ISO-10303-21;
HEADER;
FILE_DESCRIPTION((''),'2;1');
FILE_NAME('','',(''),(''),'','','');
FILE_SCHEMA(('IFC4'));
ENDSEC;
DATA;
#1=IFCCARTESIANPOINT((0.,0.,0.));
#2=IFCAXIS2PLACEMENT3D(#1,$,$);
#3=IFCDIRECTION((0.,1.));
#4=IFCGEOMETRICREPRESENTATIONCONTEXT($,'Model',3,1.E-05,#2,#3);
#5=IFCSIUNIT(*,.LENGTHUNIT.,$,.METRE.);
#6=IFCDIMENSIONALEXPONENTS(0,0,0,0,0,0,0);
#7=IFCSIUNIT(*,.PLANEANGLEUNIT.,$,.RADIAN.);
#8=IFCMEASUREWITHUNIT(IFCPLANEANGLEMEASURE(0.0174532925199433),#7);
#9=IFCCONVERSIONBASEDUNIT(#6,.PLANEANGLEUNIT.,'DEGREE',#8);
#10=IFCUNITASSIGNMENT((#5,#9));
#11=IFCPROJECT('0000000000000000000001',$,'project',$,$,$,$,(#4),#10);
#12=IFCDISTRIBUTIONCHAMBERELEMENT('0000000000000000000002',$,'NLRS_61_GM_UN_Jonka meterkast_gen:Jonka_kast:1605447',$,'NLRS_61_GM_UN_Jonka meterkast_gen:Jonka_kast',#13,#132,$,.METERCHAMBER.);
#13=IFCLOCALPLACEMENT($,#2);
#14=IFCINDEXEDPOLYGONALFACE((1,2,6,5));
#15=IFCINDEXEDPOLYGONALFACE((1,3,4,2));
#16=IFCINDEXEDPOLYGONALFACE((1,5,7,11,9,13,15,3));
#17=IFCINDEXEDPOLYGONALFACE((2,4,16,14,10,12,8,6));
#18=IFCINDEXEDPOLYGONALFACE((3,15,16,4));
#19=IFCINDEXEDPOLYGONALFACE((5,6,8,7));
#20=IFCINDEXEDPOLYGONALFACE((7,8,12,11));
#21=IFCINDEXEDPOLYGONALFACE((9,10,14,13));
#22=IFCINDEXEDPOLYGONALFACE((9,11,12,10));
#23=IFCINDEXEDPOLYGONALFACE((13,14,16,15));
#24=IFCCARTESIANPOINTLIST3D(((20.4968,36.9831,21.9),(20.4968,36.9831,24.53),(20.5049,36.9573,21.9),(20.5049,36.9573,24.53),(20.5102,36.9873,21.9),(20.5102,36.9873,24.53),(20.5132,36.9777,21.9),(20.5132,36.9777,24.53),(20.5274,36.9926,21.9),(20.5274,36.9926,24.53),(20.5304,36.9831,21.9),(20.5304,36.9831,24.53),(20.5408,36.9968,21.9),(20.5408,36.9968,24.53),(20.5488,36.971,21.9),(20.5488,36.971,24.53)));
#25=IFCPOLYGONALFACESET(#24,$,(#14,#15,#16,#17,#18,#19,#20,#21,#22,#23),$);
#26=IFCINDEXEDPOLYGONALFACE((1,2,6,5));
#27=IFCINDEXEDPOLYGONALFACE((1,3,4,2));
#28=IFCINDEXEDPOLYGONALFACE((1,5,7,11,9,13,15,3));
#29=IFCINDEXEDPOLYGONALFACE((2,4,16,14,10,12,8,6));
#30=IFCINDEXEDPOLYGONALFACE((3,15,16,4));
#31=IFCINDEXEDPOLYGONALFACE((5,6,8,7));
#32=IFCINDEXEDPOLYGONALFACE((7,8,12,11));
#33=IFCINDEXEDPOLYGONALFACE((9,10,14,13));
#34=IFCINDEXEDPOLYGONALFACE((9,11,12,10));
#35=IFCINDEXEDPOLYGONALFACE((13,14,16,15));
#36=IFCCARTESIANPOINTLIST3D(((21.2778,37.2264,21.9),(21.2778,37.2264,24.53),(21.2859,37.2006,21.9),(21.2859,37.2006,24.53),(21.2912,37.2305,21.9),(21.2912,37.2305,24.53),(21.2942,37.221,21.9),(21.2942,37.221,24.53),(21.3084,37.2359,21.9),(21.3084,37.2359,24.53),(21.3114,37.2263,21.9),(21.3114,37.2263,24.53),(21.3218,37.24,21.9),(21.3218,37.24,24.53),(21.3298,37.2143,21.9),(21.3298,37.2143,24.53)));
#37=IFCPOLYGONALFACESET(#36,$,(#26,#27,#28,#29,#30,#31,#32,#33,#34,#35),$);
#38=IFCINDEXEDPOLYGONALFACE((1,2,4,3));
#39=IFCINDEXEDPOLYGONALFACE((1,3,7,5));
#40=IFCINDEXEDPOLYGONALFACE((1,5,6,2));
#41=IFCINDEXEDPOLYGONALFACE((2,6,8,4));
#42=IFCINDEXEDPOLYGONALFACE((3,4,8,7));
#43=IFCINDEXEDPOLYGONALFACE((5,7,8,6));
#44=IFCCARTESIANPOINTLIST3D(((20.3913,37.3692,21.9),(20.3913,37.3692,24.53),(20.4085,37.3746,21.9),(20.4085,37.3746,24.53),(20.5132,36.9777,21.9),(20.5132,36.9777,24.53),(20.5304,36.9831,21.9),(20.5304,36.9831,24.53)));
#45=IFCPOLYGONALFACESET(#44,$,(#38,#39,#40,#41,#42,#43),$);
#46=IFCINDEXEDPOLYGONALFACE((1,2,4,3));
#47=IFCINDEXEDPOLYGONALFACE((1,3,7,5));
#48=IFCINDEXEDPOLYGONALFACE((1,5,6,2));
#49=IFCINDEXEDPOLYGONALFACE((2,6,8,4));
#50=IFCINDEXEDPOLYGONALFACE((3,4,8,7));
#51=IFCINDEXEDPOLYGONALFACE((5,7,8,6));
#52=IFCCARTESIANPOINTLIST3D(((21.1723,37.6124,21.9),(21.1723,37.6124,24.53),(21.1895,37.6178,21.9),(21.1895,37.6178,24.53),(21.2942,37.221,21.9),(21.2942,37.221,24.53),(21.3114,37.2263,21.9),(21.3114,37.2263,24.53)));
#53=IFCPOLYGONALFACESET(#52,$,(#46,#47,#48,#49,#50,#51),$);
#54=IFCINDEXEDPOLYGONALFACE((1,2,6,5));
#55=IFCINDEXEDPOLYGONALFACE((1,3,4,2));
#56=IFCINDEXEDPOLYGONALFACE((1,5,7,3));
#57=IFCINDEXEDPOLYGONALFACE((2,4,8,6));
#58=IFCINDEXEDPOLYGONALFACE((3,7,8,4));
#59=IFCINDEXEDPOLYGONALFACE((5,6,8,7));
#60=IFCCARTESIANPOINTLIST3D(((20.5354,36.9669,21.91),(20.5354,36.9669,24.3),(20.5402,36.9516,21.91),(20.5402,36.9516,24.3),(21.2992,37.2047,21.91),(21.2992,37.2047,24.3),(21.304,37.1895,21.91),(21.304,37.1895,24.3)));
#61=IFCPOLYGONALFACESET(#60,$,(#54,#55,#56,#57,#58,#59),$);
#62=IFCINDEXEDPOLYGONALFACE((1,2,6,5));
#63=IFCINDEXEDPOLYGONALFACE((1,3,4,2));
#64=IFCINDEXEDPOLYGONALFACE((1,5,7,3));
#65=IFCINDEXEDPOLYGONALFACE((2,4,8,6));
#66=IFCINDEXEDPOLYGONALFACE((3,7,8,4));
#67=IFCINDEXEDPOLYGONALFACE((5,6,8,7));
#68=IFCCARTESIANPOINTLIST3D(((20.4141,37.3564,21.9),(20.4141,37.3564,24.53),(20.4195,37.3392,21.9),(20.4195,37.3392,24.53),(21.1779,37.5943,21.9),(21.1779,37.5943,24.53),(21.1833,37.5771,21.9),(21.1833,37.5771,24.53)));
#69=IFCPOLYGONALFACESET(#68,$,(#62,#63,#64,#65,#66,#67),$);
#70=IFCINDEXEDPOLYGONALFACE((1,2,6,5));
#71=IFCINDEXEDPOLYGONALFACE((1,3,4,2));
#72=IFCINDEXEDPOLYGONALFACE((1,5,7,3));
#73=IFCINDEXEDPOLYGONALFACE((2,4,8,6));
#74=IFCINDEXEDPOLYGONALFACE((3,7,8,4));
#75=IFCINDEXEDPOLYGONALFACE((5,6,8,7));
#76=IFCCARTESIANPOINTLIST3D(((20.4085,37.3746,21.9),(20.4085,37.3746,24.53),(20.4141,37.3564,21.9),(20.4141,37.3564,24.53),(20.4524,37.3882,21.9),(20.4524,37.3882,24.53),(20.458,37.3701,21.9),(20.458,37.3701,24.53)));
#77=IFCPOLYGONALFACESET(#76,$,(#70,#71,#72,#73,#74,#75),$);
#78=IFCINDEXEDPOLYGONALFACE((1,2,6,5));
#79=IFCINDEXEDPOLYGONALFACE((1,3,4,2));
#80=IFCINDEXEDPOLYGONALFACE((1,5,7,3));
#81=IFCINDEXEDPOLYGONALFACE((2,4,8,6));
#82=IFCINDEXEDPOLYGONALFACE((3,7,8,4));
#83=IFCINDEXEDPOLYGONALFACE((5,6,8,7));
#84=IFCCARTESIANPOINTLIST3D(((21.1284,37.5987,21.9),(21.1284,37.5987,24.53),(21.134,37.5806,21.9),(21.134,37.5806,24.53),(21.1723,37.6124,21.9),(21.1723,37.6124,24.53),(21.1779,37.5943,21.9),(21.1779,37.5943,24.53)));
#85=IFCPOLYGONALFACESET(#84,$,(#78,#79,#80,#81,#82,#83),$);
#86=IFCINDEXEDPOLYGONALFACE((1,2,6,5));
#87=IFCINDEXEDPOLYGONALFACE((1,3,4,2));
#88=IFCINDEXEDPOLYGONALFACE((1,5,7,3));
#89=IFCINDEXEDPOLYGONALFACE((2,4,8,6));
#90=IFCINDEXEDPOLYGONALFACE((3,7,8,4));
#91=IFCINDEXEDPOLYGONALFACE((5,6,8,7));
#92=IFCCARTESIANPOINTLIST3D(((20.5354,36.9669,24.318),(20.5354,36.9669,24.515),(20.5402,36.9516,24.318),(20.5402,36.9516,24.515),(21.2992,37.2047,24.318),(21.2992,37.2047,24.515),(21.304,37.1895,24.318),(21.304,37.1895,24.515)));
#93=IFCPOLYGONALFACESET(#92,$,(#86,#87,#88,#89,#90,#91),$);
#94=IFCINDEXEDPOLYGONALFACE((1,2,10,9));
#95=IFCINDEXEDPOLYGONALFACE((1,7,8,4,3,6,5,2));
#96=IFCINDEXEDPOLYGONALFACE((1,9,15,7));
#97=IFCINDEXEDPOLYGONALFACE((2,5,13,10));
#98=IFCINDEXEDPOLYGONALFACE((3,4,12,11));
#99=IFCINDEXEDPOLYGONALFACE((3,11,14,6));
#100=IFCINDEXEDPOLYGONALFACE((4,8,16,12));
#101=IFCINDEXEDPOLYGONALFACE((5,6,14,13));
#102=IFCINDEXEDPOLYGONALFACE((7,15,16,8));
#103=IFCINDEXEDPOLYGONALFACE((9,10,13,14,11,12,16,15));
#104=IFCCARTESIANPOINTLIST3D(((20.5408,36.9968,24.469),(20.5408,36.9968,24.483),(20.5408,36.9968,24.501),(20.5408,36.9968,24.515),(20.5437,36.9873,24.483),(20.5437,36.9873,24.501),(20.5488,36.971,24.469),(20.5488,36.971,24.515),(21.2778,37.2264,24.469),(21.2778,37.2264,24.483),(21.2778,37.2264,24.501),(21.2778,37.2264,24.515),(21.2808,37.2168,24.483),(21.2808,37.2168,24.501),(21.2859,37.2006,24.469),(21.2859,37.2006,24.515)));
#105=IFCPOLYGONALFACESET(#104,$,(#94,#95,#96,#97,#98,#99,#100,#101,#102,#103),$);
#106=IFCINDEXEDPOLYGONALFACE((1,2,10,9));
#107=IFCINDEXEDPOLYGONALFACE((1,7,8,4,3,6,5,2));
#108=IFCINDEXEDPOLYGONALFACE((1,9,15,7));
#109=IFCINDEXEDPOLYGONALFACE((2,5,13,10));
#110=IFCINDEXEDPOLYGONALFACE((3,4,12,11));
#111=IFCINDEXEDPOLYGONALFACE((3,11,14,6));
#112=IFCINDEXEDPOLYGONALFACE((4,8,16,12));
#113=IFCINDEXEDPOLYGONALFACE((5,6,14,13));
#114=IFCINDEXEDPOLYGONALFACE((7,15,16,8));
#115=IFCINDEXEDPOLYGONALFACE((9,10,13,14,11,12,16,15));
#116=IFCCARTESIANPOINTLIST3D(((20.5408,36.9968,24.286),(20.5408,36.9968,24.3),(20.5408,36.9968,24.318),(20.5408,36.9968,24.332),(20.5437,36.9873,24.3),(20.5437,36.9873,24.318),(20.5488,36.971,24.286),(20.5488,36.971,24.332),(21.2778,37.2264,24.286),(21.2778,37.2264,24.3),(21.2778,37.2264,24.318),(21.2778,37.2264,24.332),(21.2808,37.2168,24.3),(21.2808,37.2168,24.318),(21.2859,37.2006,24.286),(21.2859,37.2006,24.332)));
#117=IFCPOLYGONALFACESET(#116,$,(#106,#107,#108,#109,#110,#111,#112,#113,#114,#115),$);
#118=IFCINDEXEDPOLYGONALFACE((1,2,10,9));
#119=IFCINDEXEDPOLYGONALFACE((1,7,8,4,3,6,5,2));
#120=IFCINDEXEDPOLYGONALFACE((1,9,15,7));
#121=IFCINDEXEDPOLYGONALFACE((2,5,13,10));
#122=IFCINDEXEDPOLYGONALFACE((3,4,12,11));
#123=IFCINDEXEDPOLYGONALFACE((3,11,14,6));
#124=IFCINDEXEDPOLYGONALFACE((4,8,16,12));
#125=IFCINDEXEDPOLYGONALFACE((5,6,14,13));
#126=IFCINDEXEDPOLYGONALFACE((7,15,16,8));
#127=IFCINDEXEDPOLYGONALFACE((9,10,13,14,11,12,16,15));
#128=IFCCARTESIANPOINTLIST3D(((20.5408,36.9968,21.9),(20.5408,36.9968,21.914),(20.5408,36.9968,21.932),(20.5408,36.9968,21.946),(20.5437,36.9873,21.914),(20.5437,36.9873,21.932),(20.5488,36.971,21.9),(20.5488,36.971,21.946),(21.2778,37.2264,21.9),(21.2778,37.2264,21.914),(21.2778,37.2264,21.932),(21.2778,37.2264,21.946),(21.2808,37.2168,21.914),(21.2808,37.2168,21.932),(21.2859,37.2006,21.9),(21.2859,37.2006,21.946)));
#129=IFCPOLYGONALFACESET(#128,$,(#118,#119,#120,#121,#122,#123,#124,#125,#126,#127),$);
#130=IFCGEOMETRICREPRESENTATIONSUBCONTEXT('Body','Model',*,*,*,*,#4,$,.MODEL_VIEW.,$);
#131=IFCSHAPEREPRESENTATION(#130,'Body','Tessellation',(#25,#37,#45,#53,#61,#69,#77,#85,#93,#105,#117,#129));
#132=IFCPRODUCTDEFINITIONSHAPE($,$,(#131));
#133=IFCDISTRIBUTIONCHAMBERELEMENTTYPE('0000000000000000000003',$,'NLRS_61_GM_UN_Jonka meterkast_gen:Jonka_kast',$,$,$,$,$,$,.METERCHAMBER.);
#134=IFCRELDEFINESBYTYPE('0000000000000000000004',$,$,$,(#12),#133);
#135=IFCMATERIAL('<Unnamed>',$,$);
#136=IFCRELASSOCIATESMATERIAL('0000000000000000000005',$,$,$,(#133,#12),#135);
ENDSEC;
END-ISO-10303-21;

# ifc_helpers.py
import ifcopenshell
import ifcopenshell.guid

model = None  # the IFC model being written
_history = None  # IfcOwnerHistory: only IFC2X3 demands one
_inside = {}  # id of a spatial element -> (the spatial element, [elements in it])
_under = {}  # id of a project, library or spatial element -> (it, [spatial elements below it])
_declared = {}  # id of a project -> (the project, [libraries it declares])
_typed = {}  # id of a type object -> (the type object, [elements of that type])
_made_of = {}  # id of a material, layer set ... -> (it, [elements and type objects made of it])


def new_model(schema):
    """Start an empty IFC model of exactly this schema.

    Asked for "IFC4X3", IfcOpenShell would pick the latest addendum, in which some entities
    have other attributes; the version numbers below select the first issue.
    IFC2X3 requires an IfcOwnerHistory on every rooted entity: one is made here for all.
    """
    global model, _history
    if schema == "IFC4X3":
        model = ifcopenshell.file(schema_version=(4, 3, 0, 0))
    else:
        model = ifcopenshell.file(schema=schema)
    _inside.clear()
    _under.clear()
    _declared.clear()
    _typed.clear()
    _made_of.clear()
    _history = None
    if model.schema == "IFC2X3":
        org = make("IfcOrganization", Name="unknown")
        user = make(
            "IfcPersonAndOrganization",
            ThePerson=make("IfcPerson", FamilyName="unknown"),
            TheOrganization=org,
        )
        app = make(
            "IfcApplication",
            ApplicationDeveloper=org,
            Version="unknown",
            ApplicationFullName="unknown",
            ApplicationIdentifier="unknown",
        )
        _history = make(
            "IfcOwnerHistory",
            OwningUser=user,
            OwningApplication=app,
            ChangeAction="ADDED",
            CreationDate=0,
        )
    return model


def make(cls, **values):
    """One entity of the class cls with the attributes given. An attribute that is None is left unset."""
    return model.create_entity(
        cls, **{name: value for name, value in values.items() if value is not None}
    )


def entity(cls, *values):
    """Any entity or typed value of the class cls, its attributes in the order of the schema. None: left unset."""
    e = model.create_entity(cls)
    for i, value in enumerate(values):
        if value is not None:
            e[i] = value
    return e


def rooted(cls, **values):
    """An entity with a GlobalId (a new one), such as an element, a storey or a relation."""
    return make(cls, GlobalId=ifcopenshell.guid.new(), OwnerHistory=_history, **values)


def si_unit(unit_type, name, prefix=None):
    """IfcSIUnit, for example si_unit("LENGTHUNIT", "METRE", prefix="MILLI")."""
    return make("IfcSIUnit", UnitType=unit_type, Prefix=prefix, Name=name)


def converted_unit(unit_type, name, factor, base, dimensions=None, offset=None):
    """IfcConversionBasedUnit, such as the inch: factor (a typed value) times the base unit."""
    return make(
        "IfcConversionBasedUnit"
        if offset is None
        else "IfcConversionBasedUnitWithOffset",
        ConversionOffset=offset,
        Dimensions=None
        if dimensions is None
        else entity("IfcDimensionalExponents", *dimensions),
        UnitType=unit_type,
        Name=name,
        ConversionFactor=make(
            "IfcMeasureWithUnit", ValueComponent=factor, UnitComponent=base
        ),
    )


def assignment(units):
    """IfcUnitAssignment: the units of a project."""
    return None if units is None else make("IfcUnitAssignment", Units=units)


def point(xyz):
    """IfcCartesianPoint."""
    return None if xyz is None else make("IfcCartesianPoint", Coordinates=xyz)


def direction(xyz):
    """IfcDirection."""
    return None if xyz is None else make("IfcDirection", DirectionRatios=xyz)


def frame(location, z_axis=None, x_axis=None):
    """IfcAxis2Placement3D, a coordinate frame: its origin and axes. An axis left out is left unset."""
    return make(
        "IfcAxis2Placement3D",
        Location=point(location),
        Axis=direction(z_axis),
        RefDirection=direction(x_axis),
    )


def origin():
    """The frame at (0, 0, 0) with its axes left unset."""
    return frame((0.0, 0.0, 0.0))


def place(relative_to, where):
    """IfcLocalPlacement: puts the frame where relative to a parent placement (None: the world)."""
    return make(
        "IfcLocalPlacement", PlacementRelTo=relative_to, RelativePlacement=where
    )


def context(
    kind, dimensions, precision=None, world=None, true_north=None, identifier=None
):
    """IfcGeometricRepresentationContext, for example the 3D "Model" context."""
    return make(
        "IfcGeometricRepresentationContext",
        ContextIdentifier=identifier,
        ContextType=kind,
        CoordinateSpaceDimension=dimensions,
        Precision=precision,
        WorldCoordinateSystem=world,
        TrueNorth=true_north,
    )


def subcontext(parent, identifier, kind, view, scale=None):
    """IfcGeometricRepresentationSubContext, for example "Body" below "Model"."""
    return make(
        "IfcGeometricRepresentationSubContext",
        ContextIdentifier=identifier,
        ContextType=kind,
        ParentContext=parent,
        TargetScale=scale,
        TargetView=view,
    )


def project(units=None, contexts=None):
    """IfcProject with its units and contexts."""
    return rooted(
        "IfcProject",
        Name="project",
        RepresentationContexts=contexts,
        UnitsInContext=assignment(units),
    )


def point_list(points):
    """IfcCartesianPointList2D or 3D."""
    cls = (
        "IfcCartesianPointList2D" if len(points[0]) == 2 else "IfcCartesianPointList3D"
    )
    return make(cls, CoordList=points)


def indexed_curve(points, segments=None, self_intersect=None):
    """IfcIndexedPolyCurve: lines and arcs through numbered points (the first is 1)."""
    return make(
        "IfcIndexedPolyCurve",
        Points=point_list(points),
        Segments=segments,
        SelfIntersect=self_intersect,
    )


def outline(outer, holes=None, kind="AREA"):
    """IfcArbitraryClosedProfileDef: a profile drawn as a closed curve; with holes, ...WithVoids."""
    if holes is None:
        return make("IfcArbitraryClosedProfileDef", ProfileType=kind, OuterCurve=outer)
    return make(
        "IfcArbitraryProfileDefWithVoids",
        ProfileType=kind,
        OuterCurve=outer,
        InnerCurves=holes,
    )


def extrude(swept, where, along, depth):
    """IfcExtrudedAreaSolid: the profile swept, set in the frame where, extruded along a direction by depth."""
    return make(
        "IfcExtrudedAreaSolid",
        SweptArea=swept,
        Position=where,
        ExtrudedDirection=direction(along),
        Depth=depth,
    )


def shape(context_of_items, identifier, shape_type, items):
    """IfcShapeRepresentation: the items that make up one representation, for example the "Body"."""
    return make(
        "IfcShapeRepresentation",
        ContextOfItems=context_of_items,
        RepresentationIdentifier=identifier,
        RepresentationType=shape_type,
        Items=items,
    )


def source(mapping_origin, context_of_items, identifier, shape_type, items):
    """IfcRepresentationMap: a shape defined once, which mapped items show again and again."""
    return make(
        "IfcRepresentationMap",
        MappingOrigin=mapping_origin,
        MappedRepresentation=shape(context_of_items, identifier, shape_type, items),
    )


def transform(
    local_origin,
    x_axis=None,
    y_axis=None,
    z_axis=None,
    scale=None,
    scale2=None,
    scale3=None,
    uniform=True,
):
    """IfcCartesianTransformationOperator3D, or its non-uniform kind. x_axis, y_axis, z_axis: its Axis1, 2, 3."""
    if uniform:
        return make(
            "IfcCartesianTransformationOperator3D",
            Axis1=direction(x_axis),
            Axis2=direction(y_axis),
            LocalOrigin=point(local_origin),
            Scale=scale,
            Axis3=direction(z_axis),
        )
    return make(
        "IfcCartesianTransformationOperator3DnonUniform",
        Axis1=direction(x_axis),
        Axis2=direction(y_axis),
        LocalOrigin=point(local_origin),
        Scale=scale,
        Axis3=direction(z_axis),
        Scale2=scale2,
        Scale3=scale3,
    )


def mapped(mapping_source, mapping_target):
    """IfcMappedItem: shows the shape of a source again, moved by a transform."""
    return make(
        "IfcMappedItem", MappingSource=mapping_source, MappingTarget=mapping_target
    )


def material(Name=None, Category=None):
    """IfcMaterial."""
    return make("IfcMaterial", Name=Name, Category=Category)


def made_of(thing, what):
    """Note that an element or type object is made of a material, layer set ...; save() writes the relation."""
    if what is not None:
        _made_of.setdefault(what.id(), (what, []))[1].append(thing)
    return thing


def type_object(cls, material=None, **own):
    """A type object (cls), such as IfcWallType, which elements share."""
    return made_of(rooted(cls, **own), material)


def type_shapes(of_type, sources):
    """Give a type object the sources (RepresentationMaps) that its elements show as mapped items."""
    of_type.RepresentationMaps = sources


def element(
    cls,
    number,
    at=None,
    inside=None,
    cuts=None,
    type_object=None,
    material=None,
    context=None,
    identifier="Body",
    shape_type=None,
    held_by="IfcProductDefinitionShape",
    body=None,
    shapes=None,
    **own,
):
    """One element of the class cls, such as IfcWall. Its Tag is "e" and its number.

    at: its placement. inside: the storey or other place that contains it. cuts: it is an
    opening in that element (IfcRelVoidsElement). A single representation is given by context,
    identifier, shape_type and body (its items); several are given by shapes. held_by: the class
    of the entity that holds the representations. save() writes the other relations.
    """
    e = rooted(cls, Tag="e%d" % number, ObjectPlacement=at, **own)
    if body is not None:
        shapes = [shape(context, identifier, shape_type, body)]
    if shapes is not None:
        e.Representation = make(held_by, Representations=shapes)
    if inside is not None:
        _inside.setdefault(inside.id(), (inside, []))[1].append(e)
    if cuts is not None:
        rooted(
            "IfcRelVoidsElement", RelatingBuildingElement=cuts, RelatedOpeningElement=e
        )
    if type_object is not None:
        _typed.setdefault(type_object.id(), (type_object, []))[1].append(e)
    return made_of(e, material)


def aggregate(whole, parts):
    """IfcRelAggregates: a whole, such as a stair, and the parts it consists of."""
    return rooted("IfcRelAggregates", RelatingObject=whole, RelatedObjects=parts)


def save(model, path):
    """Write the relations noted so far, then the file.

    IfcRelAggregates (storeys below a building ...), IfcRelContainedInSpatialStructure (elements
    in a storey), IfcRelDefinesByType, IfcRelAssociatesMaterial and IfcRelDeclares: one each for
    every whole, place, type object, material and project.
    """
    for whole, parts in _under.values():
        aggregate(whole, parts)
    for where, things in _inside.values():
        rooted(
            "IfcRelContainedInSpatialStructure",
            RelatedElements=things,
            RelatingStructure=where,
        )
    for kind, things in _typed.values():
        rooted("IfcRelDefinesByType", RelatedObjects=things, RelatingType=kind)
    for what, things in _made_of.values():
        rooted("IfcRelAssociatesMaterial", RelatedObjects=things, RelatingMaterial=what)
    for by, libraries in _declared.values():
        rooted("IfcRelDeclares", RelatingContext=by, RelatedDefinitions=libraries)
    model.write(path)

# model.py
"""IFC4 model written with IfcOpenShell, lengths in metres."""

from ifc_helpers import new_model, entity, si_unit, converted_unit, direction, frame, origin, place, context, subcontext, project, indexed_curve, outline, extrude, source, transform, mapped, material, type_object, type_shapes, element, save


model = new_model("IFC4")

# Units and contexts
model_context = context("Model", 3, precision=1e-05, world=origin(), true_north=direction((0.0, 1.0)))
body_context = subcontext(model_context, "Body", "Model", "MODEL_VIEW")
ifc_project = project(units=[si_unit("LENGTHUNIT", "METRE"), converted_unit("PLANEANGLEUNIT", "DEGREE", entity("IfcPlaneAngleMeasure", 0.0174532925199433), si_unit("PLANEANGLEUNIT", "RADIAN"), dimensions=[0, 0, 0, 0, 0, 0, 0])], contexts=[model_context])

# Distribution chamber element
ifc_material = material(Name="<Unnamed>")
distribution_chamber_element_type = type_object("IfcDistributionChamberElementType", Name="NLRS_61_GM_UN_Jonka meterkast_gen:Jonka_kast", PredefinedType="METERCHAMBER", material=ifc_material)
shared_shape_1 = source(origin(), body_context, "Body", "SweptSolid", [
    extrude(outline(indexed_curve([(-0.0093, -0.023), (0.0178, -0.023), (0.0178, 0.023), (-0.0093, 0.023), (-0.0093, 0.009), (0.0007, 0.009), (0.0007, -0.009), (-0.0093, -0.009), (-0.0093, -0.023)], self_intersect=False)), frame((-0.409, -0.4092, 0.0), z_axis=(0.0, 0.0, 1.0), x_axis=(0.0, -1.0, 0.0)), (0.0, 0.0, 1.0), 2.63),
    extrude(outline(indexed_curve([(-0.0093, -0.023), (0.0178, -0.023), (0.0178, 0.023), (-0.0093, 0.023), (-0.0093, 0.009), (0.0007, 0.009), (0.0007, -0.009), (-0.0093, -0.009), (-0.0093, -0.023)], self_intersect=False)), frame((0.409, -0.4092, 0.0), z_axis=(0.0, 0.0, 1.0), x_axis=(0.0, -1.0, 0.0)), (0.0, 0.0, 1.0), 2.63),
    extrude(outline(indexed_curve([(-0.205, -0.009), (0.205, -0.009), (0.205, 0.009), (-0.205, 0.009), (-0.205, -0.009)], self_intersect=False)), frame((-0.409, -0.205, 0.0), z_axis=(0.0, 0.0, 1.0), x_axis=(0.0, -1.0, 0.0)), (0.0, 0.0, 1.0), 2.63),
    extrude(outline(indexed_curve([(-0.205, -0.009), (0.205, -0.009), (0.205, 0.009), (-0.205, 0.009), (-0.205, -0.009)], self_intersect=False)), frame((0.409, -0.205, 0.0), z_axis=(0.0, 0.0, 1.0), x_axis=(0.0, -1.0, 0.0)), (0.0, 0.0, 1.0), 2.63),
    extrude(outline(indexed_curve([(-0.4, -0.008), (0.4, -0.008), (0.4, 0.008), (-0.4, 0.008), (-0.4, -0.008)], self_intersect=False)), frame((0.0, -0.435, 0.01), z_axis=(0.0, 0.0, 1.0), x_axis=(-1.0, 0.0, 0.0)), (0.0, 0.0, 1.0), 2.39),
    extrude(outline(indexed_curve([(-0.4, -0.009), (0.4, -0.009), (0.4, 0.009), (-0.4, 0.009), (-0.4, -0.009)], self_intersect=False)), frame((0.0, -0.028, 0.0), z_axis=(0.0, 0.0, 1.0), x_axis=(-1.0, 0.0, 0.0)), (0.0, 0.0, 1.0), 2.63),
    extrude(outline(indexed_curve([(-0.023, -0.0095), (0.023, -0.0095), (0.023, 0.0095), (-0.023, 0.0095), (-0.023, -0.0095)], self_intersect=False)), frame((-0.377, -0.0095, 0.0), z_axis=(0.0, 0.0, 1.0), x_axis=(-1.0, 0.0, 0.0)), (0.0, 0.0, 1.0), 2.63),
    extrude(outline(indexed_curve([(-0.023, -0.0095), (0.023, -0.0095), (0.023, 0.0095), (-0.023, 0.0095), (-0.023, -0.0095)], self_intersect=False)), frame((0.377, -0.0095, 0.0), z_axis=(0.0, 0.0, 1.0), x_axis=(-1.0, 0.0, 0.0)), (0.0, 0.0, 1.0), 2.63),
    extrude(outline(indexed_curve([(-0.4, -0.008), (0.4, -0.008), (0.4, 0.008), (-0.4, 0.008), (-0.4, -0.008)], self_intersect=False)), frame((0.0, -0.435, 2.418), z_axis=(0.0, 0.0, 1.0), x_axis=(-1.0, 0.0, 0.0)), (0.0, 0.0, 1.0), 0.197),
    extrude(outline(indexed_curve([(-0.023, -0.0178), (0.023, -0.0178), (0.023, 0.0093), (0.009, 0.0093), (0.009, -0.0007), (-0.009, -0.0007), (-0.009, 0.0093), (-0.023, 0.0093), (-0.023, -0.0178)], self_intersect=False)), frame((-0.386, -0.4092, 2.592), z_axis=(1.0, 0.0, 0.0), x_axis=(0.0, 0.0, -1.0)), (0.0, 0.0, 1.0), 0.772),
    extrude(outline(indexed_curve([(-0.023, -0.0178), (0.023, -0.0178), (0.023, 0.0093), (0.009, 0.0093), (0.009, -0.0007), (-0.009, -0.0007), (-0.009, 0.0093), (-0.023, 0.0093), (-0.023, -0.0178)], self_intersect=False)), frame((-0.386, -0.4092, 2.409), z_axis=(1.0, 0.0, 0.0), x_axis=(0.0, 0.0, -1.0)), (0.0, 0.0, 1.0), 0.772),
    extrude(outline(indexed_curve([(-0.023, -0.0178), (0.023, -0.0178), (0.023, 0.0093), (0.009, 0.0093), (0.009, -0.0007), (-0.009, -0.0007), (-0.009, 0.0093), (-0.023, 0.0093), (-0.023, -0.0178)], self_intersect=False)), frame((-0.386, -0.4092, 0.023), z_axis=(1.0, 0.0, 0.0), x_axis=(0.0, 0.0, -1.0)), (0.0, 0.0, 1.0), 0.772),
])
type_shapes(distribution_chamber_element_type, [shared_shape_1])
placement_1 = place(None, frame((13.1348, 11.9886, 0.0), z_axis=(0.0, 0.0, 1.0), x_axis=(0.954771, 0.297342, 0.0)))
placement_2 = place(placement_1, origin())
placement_3 = place(placement_2, frame((0.0, 0.0, 21.9)))
placement_4 = place(placement_3, origin())
distribution_chamber_element_1_placement = place(placement_4, frame((14.893, 22.075, 0.0)))
element("IfcDistributionChamberElement", 1, at=distribution_chamber_element_1_placement, type_object=distribution_chamber_element_type, material=ifc_material, Name="NLRS_61_GM_UN_Jonka meterkast_gen:Jonka_kast:1605447", ObjectType="NLRS_61_GM_UN_Jonka meterkast_gen:Jonka_kast", PredefinedType="METERCHAMBER", context=body_context, shape_type="MappedRepresentation", body=[
    mapped(shared_shape_1, transform((0.0, 0.0, 0.0), scale=1.0)),
])

save(model, "model.ifc")
